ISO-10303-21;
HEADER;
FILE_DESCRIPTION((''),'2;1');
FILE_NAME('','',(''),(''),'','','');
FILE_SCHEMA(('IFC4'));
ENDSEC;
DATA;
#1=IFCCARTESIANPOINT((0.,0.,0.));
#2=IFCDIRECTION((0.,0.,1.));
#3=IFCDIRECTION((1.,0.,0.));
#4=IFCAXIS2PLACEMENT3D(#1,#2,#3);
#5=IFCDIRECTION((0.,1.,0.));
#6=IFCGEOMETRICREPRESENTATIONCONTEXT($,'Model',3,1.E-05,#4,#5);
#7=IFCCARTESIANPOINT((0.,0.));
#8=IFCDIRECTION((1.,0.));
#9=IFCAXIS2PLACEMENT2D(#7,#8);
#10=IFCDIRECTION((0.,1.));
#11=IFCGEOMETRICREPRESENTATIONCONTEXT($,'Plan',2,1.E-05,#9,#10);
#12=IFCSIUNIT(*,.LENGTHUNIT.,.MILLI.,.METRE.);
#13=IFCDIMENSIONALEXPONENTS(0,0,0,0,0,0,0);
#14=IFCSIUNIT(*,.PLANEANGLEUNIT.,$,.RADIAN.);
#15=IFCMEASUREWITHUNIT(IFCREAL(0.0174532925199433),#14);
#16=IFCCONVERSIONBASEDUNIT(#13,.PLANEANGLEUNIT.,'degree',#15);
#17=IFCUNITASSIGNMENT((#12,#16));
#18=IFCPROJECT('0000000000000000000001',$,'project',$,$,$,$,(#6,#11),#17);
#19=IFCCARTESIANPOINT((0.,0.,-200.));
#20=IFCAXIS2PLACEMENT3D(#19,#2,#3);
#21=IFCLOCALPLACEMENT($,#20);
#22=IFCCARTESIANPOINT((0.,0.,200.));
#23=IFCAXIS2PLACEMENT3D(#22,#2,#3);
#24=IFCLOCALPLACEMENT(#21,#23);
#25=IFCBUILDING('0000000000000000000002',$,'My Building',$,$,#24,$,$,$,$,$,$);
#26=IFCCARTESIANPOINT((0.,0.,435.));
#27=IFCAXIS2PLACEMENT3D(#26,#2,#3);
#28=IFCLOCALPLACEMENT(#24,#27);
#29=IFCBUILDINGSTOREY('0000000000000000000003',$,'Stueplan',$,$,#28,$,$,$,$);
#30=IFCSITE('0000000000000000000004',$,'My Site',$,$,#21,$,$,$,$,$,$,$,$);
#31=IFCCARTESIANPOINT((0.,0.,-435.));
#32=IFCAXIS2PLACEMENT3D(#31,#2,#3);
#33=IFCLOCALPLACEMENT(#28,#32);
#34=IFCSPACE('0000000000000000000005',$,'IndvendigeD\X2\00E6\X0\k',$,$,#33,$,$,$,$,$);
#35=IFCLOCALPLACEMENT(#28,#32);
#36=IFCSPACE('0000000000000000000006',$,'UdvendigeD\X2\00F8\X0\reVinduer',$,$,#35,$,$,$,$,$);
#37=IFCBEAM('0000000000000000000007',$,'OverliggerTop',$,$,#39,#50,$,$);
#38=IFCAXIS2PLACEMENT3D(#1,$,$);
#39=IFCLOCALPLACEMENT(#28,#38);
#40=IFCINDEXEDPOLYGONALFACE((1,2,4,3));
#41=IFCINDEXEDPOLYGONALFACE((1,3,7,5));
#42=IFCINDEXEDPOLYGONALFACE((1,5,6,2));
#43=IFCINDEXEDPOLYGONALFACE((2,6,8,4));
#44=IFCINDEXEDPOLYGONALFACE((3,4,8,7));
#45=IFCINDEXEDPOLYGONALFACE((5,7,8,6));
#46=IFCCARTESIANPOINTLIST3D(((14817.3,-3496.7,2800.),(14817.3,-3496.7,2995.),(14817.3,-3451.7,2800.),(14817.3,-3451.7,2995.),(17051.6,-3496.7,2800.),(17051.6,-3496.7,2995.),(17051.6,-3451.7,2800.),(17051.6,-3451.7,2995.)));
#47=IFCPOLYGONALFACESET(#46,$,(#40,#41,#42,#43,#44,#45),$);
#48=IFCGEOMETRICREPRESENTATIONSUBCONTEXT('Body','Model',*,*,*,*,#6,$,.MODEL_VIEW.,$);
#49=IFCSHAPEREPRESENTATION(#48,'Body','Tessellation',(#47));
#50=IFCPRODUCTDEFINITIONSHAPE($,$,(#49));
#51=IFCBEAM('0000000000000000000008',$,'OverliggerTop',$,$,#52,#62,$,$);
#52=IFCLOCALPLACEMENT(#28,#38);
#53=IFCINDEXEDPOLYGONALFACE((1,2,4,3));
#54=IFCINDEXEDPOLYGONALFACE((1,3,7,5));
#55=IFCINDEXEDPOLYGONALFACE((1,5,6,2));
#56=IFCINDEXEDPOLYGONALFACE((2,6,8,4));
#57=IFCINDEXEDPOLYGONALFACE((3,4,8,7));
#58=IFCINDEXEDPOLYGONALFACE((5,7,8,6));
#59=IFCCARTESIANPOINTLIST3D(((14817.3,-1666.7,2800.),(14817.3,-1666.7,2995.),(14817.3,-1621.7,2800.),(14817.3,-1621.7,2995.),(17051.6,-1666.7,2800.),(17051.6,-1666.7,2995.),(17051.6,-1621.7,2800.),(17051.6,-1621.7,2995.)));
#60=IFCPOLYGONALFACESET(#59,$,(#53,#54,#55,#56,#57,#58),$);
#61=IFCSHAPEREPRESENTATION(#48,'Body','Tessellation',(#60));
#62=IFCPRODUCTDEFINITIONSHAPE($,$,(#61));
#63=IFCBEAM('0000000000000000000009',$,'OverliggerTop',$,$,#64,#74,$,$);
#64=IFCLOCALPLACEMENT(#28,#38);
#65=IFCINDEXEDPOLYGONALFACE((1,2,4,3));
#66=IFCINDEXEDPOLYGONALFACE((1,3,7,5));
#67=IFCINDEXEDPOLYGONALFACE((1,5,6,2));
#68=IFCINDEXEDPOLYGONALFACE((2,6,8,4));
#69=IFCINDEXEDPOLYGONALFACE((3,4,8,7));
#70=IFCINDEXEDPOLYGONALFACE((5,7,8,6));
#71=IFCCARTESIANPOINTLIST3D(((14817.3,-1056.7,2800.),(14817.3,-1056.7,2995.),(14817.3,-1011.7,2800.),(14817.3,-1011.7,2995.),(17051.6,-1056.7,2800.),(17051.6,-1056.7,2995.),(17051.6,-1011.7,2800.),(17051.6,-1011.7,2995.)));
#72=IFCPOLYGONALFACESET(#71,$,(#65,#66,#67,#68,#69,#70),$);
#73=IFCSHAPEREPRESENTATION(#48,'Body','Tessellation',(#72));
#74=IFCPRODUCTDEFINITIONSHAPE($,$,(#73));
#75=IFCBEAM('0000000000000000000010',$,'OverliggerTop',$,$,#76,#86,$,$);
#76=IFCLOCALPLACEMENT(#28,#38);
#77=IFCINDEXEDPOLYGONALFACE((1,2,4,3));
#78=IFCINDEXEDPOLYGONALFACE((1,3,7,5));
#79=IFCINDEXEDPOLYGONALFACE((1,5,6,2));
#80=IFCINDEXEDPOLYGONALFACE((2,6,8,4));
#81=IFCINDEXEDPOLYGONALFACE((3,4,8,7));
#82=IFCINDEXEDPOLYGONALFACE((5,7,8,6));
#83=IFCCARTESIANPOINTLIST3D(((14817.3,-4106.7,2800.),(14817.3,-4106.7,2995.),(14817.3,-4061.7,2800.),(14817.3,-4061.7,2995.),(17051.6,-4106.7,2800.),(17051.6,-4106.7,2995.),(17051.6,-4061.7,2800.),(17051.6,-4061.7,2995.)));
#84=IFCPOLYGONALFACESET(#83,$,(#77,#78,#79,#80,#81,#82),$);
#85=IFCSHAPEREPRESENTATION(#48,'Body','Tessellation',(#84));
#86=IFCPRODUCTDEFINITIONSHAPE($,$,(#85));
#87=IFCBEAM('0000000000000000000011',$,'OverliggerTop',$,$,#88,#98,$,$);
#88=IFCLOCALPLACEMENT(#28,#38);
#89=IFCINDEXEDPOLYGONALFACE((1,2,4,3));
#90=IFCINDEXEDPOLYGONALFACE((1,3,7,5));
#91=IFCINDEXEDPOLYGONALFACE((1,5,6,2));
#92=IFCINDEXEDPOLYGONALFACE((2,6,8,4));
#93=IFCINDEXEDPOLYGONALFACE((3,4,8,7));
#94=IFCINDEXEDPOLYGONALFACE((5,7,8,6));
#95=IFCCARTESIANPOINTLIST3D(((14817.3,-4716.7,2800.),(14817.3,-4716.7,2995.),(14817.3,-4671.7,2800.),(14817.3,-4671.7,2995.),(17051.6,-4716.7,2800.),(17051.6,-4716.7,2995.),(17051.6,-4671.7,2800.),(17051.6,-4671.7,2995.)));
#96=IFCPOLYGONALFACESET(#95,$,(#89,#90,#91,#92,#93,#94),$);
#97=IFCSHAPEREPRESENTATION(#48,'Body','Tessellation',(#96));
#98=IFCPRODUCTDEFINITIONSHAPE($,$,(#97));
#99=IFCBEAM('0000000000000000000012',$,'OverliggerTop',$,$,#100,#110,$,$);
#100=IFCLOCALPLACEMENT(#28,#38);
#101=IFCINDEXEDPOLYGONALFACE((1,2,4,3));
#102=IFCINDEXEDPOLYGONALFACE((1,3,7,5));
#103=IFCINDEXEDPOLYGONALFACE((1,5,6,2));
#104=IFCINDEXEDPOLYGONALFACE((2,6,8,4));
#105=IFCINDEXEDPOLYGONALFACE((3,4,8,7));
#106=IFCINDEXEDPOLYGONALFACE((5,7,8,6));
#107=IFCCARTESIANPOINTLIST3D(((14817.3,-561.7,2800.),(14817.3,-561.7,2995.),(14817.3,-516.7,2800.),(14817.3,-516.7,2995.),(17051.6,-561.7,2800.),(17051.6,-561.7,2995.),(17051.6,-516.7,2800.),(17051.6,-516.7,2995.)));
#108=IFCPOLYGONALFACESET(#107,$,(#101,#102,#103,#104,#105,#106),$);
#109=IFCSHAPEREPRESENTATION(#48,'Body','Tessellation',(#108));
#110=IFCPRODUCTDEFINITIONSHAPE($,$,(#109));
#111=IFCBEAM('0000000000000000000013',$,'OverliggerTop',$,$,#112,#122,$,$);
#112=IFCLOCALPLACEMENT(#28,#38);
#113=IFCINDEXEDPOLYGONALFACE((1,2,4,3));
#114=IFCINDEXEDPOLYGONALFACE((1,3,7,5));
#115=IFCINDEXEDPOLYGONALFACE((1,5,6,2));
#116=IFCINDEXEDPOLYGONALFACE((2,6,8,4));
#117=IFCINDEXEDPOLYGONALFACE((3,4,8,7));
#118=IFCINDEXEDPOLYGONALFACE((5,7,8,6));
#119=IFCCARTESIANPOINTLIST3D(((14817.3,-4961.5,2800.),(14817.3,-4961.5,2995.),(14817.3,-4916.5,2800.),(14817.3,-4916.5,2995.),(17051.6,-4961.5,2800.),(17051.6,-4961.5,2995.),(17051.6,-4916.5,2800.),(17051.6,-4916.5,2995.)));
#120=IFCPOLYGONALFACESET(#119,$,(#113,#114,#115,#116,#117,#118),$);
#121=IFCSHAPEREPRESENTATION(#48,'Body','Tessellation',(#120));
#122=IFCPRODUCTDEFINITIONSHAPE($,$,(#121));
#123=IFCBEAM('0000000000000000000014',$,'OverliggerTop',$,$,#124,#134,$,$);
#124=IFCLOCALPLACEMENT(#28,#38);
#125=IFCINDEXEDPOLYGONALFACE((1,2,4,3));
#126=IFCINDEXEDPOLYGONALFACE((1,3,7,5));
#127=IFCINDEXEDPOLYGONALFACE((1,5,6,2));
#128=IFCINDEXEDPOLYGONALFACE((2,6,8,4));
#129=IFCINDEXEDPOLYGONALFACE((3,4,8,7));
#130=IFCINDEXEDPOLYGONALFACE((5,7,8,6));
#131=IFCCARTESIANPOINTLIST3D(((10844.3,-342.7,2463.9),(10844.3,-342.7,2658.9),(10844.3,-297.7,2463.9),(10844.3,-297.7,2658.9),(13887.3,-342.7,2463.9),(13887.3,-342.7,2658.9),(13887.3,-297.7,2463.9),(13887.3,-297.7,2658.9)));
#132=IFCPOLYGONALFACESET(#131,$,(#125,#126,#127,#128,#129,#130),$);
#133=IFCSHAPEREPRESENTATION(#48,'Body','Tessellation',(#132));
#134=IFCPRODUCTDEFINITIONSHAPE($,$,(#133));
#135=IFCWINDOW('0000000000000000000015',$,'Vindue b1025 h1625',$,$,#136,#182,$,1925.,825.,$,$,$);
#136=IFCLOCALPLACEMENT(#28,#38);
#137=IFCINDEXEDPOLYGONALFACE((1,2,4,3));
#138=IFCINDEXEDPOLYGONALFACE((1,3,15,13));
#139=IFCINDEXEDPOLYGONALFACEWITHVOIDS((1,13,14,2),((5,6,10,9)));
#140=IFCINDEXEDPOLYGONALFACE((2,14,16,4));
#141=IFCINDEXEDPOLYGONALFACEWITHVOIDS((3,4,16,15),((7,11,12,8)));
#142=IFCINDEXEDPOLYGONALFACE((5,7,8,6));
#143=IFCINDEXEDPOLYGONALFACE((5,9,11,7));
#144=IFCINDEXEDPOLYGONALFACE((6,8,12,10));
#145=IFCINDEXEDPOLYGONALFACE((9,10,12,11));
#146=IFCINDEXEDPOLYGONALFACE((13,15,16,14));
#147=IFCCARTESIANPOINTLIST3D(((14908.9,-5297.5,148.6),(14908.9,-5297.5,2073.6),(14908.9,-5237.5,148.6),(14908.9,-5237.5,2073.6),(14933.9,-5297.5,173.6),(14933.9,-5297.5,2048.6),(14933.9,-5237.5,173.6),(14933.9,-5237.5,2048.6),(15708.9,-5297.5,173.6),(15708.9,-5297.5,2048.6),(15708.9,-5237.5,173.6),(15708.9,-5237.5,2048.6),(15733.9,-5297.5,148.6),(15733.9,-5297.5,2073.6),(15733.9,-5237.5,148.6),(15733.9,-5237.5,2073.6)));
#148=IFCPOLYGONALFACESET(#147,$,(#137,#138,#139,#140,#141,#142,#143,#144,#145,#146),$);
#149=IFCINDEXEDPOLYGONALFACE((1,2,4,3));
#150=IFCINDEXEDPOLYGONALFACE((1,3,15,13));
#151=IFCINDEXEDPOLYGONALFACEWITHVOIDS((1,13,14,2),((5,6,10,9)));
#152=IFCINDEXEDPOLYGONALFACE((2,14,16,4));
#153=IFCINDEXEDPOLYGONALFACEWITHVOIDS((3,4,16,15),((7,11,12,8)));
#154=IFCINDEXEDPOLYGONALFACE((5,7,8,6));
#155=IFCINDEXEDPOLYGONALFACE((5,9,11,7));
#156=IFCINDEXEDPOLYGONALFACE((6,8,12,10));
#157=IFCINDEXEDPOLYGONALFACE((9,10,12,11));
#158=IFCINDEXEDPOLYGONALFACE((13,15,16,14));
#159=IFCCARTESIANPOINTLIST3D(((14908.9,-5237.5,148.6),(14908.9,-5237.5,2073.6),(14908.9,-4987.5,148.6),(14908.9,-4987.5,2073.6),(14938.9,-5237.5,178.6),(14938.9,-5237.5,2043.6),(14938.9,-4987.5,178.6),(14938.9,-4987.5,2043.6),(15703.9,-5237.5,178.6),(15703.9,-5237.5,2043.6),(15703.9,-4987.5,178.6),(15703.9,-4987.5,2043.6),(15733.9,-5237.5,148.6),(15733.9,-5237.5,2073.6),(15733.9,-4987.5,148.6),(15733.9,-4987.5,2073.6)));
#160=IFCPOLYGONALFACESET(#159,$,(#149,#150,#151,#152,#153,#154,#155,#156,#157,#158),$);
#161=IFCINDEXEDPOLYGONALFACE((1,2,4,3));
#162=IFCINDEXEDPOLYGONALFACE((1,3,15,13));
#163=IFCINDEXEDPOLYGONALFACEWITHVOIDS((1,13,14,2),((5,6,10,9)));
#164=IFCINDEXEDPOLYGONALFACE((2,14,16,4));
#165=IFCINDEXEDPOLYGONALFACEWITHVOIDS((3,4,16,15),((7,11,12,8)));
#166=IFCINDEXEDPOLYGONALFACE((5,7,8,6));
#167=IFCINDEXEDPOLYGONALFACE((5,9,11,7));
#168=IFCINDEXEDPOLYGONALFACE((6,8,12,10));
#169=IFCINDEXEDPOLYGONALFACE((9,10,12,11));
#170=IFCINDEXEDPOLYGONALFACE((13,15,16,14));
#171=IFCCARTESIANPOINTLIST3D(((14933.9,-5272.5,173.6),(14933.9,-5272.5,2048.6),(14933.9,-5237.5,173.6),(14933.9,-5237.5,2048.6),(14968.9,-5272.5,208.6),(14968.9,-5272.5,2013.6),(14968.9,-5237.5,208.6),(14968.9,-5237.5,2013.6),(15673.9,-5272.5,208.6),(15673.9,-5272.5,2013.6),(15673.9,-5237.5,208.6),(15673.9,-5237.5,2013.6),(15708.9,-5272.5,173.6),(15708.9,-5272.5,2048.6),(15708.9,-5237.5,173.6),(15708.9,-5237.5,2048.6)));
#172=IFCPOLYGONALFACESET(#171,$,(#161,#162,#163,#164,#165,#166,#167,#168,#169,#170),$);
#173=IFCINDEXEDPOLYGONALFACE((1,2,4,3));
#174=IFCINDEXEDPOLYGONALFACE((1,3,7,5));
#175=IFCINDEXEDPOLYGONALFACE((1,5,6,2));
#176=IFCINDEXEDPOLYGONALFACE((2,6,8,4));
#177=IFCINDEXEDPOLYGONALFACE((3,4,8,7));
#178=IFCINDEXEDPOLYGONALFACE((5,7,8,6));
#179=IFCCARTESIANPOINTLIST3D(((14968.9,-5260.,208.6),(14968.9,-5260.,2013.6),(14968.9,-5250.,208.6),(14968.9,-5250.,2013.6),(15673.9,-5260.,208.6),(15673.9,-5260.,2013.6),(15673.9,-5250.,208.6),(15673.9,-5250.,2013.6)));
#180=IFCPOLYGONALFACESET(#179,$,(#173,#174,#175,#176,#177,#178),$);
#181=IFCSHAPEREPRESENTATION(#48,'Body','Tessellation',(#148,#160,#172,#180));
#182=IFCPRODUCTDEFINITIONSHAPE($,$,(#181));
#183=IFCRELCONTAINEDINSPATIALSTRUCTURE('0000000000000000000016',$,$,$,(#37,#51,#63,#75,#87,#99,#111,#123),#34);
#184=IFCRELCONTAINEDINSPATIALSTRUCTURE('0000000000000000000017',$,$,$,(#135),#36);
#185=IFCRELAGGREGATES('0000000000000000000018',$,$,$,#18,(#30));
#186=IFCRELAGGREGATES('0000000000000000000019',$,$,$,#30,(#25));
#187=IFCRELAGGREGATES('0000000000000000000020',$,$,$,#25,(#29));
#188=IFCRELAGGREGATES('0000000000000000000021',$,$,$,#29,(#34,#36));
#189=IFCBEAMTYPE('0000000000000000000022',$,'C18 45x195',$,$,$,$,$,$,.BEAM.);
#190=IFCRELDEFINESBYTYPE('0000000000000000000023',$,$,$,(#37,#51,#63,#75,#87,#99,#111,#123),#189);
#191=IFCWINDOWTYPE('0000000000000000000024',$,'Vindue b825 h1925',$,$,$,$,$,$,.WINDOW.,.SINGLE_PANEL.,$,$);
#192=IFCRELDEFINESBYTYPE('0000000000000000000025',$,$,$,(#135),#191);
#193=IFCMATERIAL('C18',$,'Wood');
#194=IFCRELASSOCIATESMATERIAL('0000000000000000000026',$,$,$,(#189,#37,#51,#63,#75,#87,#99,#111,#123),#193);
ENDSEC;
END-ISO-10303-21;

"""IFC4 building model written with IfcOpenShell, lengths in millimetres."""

from ifc_helpers import new_model, entity, si_unit, converted_unit, direction, frame, origin_with_axes, origin_2d_with_axis, place, context, subcontext, project, spatial, line, indexed_curve, rectangle, outline, extrude, shape, source, transform, mapped, material, material_profile, profile_set, profile_usage, type_object, type_shapes, element, save


model = new_model("IFC4")

# Units and contexts
model_context = context("Model", 3, precision=1e-05, world=origin_with_axes(), true_north=direction((0.0, 1.0, 0.0)))
plan_context = context("Plan", 2, precision=1e-05, world=origin_2d_with_axis(), true_north=direction((0.0, 1.0)))
body_context_1 = subcontext(model_context, "Body", "Model", "MODEL_VIEW")
body_context_2 = subcontext(plan_context, "Body", "Plan", "PLAN_VIEW")
ifc_project = project(units=[si_unit("LENGTHUNIT", "METRE", prefix="MILLI"), converted_unit("PLANEANGLEUNIT", "degree", entity("IfcReal", 0.0174532925199433), si_unit("PLANEANGLEUNIT", "RADIAN"), dimensions=[0, 0, 0, 0, 0, 0, 0])], contexts=[model_context, plan_context])

# Site, building, storey
site_placement = place(None, frame((0.0, 0.0, -200.0), z_axis=(0.0, 0.0, 1.0), x_axis=(1.0, 0.0, 0.0)))
site = spatial("IfcSite", under=ifc_project, at=site_placement, Name="My Site")
building_placement = place(site_placement, frame((0.0, 0.0, 200.0), z_axis=(0.0, 0.0, 1.0), x_axis=(1.0, 0.0, 0.0)))
building = spatial("IfcBuilding", under=site, at=building_placement, Name="My Building")
storey_placement = place(building_placement, frame((0.0, 0.0, 435.0), z_axis=(0.0, 0.0, 1.0), x_axis=(1.0, 0.0, 0.0)))
storey = spatial("IfcBuildingStorey", under=building, at=storey_placement, Name="Stueplan")

# Shared definitions
ifc_material = material(Name="C18", Category="Wood")

# Shared definitions
space_1_placement = place(storey_placement, frame((0.0, 0.0, -435.0), z_axis=(0.0, 0.0, 1.0), x_axis=(1.0, 0.0, 0.0)))
space_1 = spatial("IfcSpace", under=storey, at=space_1_placement, Name="IndvendigeDæk")

# Beams
ifc_material_profile_1 = material_profile(ifc_material, rectangle(XDim=45.0, YDim=195.0))
ifc_profile_set_1 = profile_set([ifc_material_profile_1], Name="woodStructural")
beam_type_1 = type_object("IfcBeamType", Name="C18 45x195", PredefinedType="BEAM", material=ifc_profile_set_1)
ifc_profile_usage_1 = profile_usage(ifc_profile_set_1)
beam_1_placement = place(space_1_placement, frame((14817.3, -3474.2, 3332.5), z_axis=(1.0, 0.000001, 0.0), x_axis=(0.000001, -1.0, 0.0)))
element("IfcBeam", 1, at=beam_1_placement, inside=space_1, type_object=beam_type_1, material=ifc_profile_usage_1, Name="OverliggerTop", context=body_context_1, shape_type="SweptSolid", body=[
    extrude(rectangle(XDim=45.0, YDim=195.0), origin_with_axes(), (0.0, 0.0, 1.0), 2234.3),
])
ifc_profile_usage_2 = profile_usage(ifc_profile_set_1)
beam_2_placement = place(space_1_placement, frame((14817.3, -1644.2, 3332.5), z_axis=(1.0, 0.000001, 0.0), x_axis=(0.000001, -1.0, 0.0)))
element("IfcBeam", 2, at=beam_2_placement, inside=space_1, type_object=beam_type_1, material=ifc_profile_usage_2, Name="OverliggerTop", context=body_context_1, shape_type="SweptSolid", body=[
    extrude(rectangle(XDim=45.0, YDim=195.0), origin_with_axes(), (0.0, 0.0, 1.0), 2234.3),
])
ifc_profile_usage_3 = profile_usage(ifc_profile_set_1)
beam_3_placement = place(space_1_placement, frame((14817.3, -1034.2, 3332.5), z_axis=(1.0, 0.000001, 0.0), x_axis=(0.000001, -1.0, 0.0)))
element("IfcBeam", 3, at=beam_3_placement, inside=space_1, type_object=beam_type_1, material=ifc_profile_usage_3, Name="OverliggerTop", context=body_context_1, shape_type="SweptSolid", body=[
    extrude(rectangle(XDim=45.0, YDim=195.0), origin_with_axes(), (0.0, 0.0, 1.0), 2234.3),
])
ifc_profile_usage_4 = profile_usage(ifc_profile_set_1)
beam_4_placement = place(space_1_placement, frame((14817.3, -4084.2, 3332.5), z_axis=(1.0, 0.000001, 0.0), x_axis=(0.000001, -1.0, 0.0)))
element("IfcBeam", 4, at=beam_4_placement, inside=space_1, type_object=beam_type_1, material=ifc_profile_usage_4, Name="OverliggerTop", context=body_context_1, shape_type="SweptSolid", body=[
    extrude(rectangle(XDim=45.0, YDim=195.0), origin_with_axes(), (0.0, 0.0, 1.0), 2234.3),
])
ifc_profile_usage_5 = profile_usage(ifc_profile_set_1)
beam_5_placement = place(space_1_placement, frame((14817.3, -4694.2, 3332.5), z_axis=(1.0, 0.000001, 0.0), x_axis=(0.000001, -1.0, 0.0)))
element("IfcBeam", 5, at=beam_5_placement, inside=space_1, type_object=beam_type_1, material=ifc_profile_usage_5, Name="OverliggerTop", context=body_context_1, shape_type="SweptSolid", body=[
    extrude(rectangle(XDim=45.0, YDim=195.0), origin_with_axes(), (0.0, 0.0, 1.0), 2234.3),
])
ifc_profile_usage_6 = profile_usage(ifc_profile_set_1)
beam_6_placement = place(space_1_placement, frame((14817.3, -539.2, 3332.5), z_axis=(1.0, 0.000001, 0.0), x_axis=(0.000001, -1.0, 0.0)))
element("IfcBeam", 6, at=beam_6_placement, inside=space_1, type_object=beam_type_1, material=ifc_profile_usage_6, Name="OverliggerTop", context=body_context_1, shape_type="SweptSolid", body=[
    extrude(rectangle(XDim=45.0, YDim=195.0), origin_with_axes(), (0.0, 0.0, 1.0), 2234.3),
])
ifc_profile_usage_7 = profile_usage(ifc_profile_set_1)
beam_7_placement = place(space_1_placement, frame((14817.3, -4939.0, 3332.5), z_axis=(1.0, 0.000001, 0.0), x_axis=(0.000001, -1.0, 0.0)))
element("IfcBeam", 7, at=beam_7_placement, inside=space_1, type_object=beam_type_1, material=ifc_profile_usage_7, Name="OverliggerTop", context=body_context_1, shape_type="SweptSolid", body=[
    extrude(rectangle(XDim=45.0, YDim=195.0), origin_with_axes(), (0.0, 0.0, 1.0), 2234.3),
])
ifc_profile_usage_8 = profile_usage(ifc_profile_set_1)
beam_8_placement = place(space_1_placement, frame((13887.3, -320.2, 2996.4), z_axis=(-1.0, 0.0, 0.0), x_axis=(0.0, 1.0, 0.0)))
element("IfcBeam", 8, at=beam_8_placement, inside=space_1, type_object=beam_type_1, material=ifc_profile_usage_8, Name="OverliggerTop", context=body_context_1, shape_type="SweptSolid", body=[
    extrude(rectangle(XDim=45.0, YDim=195.0), origin_with_axes(), (0.0, 0.0, 1.0), 3043.0),
])

# Shared definitions
space_2_placement = place(storey_placement, frame((0.0, 0.0, -435.0), z_axis=(0.0, 0.0, 1.0), x_axis=(1.0, 0.0, 0.0)))
space_2 = spatial("IfcSpace", under=storey, at=space_2_placement, Name="UdvendigeDøreVinduer")

# Window
window_type = type_object("IfcWindowType", Name="Vindue b825 h1925", PartitioningType="SINGLE_PANEL", PredefinedType="WINDOW")
shared_shape_1 = source(origin_with_axes(), body_context_1, "Body", "SweptSolid", [
    extrude(outline(indexed_curve([(0.0, 0.0), (825.0, 0.0), (825.0, 1925.0), (0.0, 1925.0)], segments=[line(1, 2, 3, 4, 1)]), holes=[indexed_curve([(25.0, 25.0), (800.0, 25.0), (800.0, 1900.0), (25.0, 1900.0)], segments=[line(1, 2, 3, 4, 1)])]), frame((0.0, 250.0, 0.0), z_axis=(0.0, -1.0, 0.0), x_axis=(1.0, 0.0, 0.0)), (0.0, 0.0, -1.0), 60.0),
    extrude(outline(indexed_curve([(0.0, 0.0), (825.0, 0.0), (825.0, 1925.0), (0.0, 1925.0)], segments=[line(1, 2, 3, 4, 1)]), holes=[indexed_curve([(30.0, 30.0), (795.0, 30.0), (795.0, 1895.0), (30.0, 1895.0)], segments=[line(1, 2, 3, 4, 1)])]), frame((0.0, 0.0, 0.0), z_axis=(0.0, -1.0, 0.0), x_axis=(1.0, 0.0, 0.0)), (0.0, 0.0, -1.0), 250.0),
    extrude(outline(indexed_curve([(0.0, 0.0), (775.0, 0.0), (775.0, 1875.0), (0.0, 1875.0)], segments=[line(1, 2, 3, 4, 1)]), holes=[indexed_curve([(35.0, 35.0), (740.0, 35.0), (740.0, 1840.0), (35.0, 1840.0)], segments=[line(1, 2, 3, 4, 1)])]), frame((25.0, 250.0, 25.0), z_axis=(0.0, -1.0, 0.0), x_axis=(1.0, 0.0, 0.0)), (0.0, 0.0, -1.0), 35.0),
    extrude(outline(indexed_curve([(35.0, 35.0), (740.0, 35.0), (740.0, 1840.0), (35.0, 1840.0)], segments=[line(1, 2, 3, 4, 1)])), frame((25.0, 262.5, 25.0), z_axis=(0.0, -1.0, 0.0), x_axis=(1.0, 0.0, 0.0)), (0.0, 0.0, -1.0), 10.0),
])
shared_shape_2 = source(origin_with_axes(), body_context_2, "Body", "Curve2D", [
    entity("IfcIndexedPolyCurve", entity("IfcCartesianPointList2D", [[30.0, 0.0], [795.0, 0.0]])),
    entity("IfcIndexedPolyCurve", entity("IfcCartesianPointList2D", [[0.0, 310.0], [25.0, 310.0], [25.0, 250.0], [30.0, 250.0], [30.0, 0.0], [0.0, 0.0]]), [entity("IfcLineIndex", [1, 2, 3, 4, 5, 6, 1])]),
    entity("IfcIndexedPolyCurve", entity("IfcCartesianPointList2D", [[825.0, 310.0], [800.0, 310.0], [800.0, 250.0], [795.0, 250.0], [795.0, 0.0], [825.0, 0.0]]), [entity("IfcLineIndex", [1, 2, 3, 4, 5, 6, 1])]),
    entity("IfcIndexedPolyCurve", entity("IfcCartesianPointList2D", [[25.0, 250.0], [60.0, 250.0], [60.0, 285.0], [25.0, 285.0]]), [entity("IfcLineIndex", [1, 2, 3, 4, 1])]),
    entity("IfcIndexedPolyCurve", entity("IfcCartesianPointList2D", [[800.0, 250.0], [765.0, 250.0], [765.0, 285.0], [800.0, 285.0]]), [entity("IfcLineIndex", [1, 2, 3, 4, 1])]),
    entity("IfcIndexedPolyCurve", entity("IfcCartesianPointList2D", [[60.0, 250.0], [765.0, 250.0]])),
    entity("IfcIndexedPolyCurve", entity("IfcCartesianPointList2D", [[60.0, 285.0], [765.0, 285.0]])),
    entity("IfcIndexedPolyCurve", entity("IfcCartesianPointList2D", [[60.0, 267.5], [765.0, 267.5]])),
])
type_shapes(window_type, [shared_shape_1, shared_shape_2])
window_placement = place(space_2_placement, frame((15733.9, -4987.5, 583.6), z_axis=(0.0, 0.0, 1.0), x_axis=(-1.0, 0.0, 0.0)))
element("IfcWindow", 9, at=window_placement, inside=space_2, type_object=window_type, Name="Vindue b1025 h1625", OverallHeight=1925.0, OverallWidth=825.0, shapes=[
    shape(body_context_1, "Body", "MappedRepresentation", [mapped(shared_shape_1, transform((0.0, 0.0, 0.0), x_axis=(1.0, 0.0, 0.0), y_axis=(0.0, 1.0, 0.0), z_axis=(0.0, 0.0, 1.0), scale=1.0))]),
    shape(body_context_2, "Body", "MappedRepresentation", [mapped(shared_shape_2, transform((0.0, 0.0, 0.0), x_axis=(1.0, 0.0, 0.0), y_axis=(0.0, 1.0, 0.0), z_axis=(0.0, 0.0, 1.0), scale=1.0))]),
])

save(model, "model.ifc")
